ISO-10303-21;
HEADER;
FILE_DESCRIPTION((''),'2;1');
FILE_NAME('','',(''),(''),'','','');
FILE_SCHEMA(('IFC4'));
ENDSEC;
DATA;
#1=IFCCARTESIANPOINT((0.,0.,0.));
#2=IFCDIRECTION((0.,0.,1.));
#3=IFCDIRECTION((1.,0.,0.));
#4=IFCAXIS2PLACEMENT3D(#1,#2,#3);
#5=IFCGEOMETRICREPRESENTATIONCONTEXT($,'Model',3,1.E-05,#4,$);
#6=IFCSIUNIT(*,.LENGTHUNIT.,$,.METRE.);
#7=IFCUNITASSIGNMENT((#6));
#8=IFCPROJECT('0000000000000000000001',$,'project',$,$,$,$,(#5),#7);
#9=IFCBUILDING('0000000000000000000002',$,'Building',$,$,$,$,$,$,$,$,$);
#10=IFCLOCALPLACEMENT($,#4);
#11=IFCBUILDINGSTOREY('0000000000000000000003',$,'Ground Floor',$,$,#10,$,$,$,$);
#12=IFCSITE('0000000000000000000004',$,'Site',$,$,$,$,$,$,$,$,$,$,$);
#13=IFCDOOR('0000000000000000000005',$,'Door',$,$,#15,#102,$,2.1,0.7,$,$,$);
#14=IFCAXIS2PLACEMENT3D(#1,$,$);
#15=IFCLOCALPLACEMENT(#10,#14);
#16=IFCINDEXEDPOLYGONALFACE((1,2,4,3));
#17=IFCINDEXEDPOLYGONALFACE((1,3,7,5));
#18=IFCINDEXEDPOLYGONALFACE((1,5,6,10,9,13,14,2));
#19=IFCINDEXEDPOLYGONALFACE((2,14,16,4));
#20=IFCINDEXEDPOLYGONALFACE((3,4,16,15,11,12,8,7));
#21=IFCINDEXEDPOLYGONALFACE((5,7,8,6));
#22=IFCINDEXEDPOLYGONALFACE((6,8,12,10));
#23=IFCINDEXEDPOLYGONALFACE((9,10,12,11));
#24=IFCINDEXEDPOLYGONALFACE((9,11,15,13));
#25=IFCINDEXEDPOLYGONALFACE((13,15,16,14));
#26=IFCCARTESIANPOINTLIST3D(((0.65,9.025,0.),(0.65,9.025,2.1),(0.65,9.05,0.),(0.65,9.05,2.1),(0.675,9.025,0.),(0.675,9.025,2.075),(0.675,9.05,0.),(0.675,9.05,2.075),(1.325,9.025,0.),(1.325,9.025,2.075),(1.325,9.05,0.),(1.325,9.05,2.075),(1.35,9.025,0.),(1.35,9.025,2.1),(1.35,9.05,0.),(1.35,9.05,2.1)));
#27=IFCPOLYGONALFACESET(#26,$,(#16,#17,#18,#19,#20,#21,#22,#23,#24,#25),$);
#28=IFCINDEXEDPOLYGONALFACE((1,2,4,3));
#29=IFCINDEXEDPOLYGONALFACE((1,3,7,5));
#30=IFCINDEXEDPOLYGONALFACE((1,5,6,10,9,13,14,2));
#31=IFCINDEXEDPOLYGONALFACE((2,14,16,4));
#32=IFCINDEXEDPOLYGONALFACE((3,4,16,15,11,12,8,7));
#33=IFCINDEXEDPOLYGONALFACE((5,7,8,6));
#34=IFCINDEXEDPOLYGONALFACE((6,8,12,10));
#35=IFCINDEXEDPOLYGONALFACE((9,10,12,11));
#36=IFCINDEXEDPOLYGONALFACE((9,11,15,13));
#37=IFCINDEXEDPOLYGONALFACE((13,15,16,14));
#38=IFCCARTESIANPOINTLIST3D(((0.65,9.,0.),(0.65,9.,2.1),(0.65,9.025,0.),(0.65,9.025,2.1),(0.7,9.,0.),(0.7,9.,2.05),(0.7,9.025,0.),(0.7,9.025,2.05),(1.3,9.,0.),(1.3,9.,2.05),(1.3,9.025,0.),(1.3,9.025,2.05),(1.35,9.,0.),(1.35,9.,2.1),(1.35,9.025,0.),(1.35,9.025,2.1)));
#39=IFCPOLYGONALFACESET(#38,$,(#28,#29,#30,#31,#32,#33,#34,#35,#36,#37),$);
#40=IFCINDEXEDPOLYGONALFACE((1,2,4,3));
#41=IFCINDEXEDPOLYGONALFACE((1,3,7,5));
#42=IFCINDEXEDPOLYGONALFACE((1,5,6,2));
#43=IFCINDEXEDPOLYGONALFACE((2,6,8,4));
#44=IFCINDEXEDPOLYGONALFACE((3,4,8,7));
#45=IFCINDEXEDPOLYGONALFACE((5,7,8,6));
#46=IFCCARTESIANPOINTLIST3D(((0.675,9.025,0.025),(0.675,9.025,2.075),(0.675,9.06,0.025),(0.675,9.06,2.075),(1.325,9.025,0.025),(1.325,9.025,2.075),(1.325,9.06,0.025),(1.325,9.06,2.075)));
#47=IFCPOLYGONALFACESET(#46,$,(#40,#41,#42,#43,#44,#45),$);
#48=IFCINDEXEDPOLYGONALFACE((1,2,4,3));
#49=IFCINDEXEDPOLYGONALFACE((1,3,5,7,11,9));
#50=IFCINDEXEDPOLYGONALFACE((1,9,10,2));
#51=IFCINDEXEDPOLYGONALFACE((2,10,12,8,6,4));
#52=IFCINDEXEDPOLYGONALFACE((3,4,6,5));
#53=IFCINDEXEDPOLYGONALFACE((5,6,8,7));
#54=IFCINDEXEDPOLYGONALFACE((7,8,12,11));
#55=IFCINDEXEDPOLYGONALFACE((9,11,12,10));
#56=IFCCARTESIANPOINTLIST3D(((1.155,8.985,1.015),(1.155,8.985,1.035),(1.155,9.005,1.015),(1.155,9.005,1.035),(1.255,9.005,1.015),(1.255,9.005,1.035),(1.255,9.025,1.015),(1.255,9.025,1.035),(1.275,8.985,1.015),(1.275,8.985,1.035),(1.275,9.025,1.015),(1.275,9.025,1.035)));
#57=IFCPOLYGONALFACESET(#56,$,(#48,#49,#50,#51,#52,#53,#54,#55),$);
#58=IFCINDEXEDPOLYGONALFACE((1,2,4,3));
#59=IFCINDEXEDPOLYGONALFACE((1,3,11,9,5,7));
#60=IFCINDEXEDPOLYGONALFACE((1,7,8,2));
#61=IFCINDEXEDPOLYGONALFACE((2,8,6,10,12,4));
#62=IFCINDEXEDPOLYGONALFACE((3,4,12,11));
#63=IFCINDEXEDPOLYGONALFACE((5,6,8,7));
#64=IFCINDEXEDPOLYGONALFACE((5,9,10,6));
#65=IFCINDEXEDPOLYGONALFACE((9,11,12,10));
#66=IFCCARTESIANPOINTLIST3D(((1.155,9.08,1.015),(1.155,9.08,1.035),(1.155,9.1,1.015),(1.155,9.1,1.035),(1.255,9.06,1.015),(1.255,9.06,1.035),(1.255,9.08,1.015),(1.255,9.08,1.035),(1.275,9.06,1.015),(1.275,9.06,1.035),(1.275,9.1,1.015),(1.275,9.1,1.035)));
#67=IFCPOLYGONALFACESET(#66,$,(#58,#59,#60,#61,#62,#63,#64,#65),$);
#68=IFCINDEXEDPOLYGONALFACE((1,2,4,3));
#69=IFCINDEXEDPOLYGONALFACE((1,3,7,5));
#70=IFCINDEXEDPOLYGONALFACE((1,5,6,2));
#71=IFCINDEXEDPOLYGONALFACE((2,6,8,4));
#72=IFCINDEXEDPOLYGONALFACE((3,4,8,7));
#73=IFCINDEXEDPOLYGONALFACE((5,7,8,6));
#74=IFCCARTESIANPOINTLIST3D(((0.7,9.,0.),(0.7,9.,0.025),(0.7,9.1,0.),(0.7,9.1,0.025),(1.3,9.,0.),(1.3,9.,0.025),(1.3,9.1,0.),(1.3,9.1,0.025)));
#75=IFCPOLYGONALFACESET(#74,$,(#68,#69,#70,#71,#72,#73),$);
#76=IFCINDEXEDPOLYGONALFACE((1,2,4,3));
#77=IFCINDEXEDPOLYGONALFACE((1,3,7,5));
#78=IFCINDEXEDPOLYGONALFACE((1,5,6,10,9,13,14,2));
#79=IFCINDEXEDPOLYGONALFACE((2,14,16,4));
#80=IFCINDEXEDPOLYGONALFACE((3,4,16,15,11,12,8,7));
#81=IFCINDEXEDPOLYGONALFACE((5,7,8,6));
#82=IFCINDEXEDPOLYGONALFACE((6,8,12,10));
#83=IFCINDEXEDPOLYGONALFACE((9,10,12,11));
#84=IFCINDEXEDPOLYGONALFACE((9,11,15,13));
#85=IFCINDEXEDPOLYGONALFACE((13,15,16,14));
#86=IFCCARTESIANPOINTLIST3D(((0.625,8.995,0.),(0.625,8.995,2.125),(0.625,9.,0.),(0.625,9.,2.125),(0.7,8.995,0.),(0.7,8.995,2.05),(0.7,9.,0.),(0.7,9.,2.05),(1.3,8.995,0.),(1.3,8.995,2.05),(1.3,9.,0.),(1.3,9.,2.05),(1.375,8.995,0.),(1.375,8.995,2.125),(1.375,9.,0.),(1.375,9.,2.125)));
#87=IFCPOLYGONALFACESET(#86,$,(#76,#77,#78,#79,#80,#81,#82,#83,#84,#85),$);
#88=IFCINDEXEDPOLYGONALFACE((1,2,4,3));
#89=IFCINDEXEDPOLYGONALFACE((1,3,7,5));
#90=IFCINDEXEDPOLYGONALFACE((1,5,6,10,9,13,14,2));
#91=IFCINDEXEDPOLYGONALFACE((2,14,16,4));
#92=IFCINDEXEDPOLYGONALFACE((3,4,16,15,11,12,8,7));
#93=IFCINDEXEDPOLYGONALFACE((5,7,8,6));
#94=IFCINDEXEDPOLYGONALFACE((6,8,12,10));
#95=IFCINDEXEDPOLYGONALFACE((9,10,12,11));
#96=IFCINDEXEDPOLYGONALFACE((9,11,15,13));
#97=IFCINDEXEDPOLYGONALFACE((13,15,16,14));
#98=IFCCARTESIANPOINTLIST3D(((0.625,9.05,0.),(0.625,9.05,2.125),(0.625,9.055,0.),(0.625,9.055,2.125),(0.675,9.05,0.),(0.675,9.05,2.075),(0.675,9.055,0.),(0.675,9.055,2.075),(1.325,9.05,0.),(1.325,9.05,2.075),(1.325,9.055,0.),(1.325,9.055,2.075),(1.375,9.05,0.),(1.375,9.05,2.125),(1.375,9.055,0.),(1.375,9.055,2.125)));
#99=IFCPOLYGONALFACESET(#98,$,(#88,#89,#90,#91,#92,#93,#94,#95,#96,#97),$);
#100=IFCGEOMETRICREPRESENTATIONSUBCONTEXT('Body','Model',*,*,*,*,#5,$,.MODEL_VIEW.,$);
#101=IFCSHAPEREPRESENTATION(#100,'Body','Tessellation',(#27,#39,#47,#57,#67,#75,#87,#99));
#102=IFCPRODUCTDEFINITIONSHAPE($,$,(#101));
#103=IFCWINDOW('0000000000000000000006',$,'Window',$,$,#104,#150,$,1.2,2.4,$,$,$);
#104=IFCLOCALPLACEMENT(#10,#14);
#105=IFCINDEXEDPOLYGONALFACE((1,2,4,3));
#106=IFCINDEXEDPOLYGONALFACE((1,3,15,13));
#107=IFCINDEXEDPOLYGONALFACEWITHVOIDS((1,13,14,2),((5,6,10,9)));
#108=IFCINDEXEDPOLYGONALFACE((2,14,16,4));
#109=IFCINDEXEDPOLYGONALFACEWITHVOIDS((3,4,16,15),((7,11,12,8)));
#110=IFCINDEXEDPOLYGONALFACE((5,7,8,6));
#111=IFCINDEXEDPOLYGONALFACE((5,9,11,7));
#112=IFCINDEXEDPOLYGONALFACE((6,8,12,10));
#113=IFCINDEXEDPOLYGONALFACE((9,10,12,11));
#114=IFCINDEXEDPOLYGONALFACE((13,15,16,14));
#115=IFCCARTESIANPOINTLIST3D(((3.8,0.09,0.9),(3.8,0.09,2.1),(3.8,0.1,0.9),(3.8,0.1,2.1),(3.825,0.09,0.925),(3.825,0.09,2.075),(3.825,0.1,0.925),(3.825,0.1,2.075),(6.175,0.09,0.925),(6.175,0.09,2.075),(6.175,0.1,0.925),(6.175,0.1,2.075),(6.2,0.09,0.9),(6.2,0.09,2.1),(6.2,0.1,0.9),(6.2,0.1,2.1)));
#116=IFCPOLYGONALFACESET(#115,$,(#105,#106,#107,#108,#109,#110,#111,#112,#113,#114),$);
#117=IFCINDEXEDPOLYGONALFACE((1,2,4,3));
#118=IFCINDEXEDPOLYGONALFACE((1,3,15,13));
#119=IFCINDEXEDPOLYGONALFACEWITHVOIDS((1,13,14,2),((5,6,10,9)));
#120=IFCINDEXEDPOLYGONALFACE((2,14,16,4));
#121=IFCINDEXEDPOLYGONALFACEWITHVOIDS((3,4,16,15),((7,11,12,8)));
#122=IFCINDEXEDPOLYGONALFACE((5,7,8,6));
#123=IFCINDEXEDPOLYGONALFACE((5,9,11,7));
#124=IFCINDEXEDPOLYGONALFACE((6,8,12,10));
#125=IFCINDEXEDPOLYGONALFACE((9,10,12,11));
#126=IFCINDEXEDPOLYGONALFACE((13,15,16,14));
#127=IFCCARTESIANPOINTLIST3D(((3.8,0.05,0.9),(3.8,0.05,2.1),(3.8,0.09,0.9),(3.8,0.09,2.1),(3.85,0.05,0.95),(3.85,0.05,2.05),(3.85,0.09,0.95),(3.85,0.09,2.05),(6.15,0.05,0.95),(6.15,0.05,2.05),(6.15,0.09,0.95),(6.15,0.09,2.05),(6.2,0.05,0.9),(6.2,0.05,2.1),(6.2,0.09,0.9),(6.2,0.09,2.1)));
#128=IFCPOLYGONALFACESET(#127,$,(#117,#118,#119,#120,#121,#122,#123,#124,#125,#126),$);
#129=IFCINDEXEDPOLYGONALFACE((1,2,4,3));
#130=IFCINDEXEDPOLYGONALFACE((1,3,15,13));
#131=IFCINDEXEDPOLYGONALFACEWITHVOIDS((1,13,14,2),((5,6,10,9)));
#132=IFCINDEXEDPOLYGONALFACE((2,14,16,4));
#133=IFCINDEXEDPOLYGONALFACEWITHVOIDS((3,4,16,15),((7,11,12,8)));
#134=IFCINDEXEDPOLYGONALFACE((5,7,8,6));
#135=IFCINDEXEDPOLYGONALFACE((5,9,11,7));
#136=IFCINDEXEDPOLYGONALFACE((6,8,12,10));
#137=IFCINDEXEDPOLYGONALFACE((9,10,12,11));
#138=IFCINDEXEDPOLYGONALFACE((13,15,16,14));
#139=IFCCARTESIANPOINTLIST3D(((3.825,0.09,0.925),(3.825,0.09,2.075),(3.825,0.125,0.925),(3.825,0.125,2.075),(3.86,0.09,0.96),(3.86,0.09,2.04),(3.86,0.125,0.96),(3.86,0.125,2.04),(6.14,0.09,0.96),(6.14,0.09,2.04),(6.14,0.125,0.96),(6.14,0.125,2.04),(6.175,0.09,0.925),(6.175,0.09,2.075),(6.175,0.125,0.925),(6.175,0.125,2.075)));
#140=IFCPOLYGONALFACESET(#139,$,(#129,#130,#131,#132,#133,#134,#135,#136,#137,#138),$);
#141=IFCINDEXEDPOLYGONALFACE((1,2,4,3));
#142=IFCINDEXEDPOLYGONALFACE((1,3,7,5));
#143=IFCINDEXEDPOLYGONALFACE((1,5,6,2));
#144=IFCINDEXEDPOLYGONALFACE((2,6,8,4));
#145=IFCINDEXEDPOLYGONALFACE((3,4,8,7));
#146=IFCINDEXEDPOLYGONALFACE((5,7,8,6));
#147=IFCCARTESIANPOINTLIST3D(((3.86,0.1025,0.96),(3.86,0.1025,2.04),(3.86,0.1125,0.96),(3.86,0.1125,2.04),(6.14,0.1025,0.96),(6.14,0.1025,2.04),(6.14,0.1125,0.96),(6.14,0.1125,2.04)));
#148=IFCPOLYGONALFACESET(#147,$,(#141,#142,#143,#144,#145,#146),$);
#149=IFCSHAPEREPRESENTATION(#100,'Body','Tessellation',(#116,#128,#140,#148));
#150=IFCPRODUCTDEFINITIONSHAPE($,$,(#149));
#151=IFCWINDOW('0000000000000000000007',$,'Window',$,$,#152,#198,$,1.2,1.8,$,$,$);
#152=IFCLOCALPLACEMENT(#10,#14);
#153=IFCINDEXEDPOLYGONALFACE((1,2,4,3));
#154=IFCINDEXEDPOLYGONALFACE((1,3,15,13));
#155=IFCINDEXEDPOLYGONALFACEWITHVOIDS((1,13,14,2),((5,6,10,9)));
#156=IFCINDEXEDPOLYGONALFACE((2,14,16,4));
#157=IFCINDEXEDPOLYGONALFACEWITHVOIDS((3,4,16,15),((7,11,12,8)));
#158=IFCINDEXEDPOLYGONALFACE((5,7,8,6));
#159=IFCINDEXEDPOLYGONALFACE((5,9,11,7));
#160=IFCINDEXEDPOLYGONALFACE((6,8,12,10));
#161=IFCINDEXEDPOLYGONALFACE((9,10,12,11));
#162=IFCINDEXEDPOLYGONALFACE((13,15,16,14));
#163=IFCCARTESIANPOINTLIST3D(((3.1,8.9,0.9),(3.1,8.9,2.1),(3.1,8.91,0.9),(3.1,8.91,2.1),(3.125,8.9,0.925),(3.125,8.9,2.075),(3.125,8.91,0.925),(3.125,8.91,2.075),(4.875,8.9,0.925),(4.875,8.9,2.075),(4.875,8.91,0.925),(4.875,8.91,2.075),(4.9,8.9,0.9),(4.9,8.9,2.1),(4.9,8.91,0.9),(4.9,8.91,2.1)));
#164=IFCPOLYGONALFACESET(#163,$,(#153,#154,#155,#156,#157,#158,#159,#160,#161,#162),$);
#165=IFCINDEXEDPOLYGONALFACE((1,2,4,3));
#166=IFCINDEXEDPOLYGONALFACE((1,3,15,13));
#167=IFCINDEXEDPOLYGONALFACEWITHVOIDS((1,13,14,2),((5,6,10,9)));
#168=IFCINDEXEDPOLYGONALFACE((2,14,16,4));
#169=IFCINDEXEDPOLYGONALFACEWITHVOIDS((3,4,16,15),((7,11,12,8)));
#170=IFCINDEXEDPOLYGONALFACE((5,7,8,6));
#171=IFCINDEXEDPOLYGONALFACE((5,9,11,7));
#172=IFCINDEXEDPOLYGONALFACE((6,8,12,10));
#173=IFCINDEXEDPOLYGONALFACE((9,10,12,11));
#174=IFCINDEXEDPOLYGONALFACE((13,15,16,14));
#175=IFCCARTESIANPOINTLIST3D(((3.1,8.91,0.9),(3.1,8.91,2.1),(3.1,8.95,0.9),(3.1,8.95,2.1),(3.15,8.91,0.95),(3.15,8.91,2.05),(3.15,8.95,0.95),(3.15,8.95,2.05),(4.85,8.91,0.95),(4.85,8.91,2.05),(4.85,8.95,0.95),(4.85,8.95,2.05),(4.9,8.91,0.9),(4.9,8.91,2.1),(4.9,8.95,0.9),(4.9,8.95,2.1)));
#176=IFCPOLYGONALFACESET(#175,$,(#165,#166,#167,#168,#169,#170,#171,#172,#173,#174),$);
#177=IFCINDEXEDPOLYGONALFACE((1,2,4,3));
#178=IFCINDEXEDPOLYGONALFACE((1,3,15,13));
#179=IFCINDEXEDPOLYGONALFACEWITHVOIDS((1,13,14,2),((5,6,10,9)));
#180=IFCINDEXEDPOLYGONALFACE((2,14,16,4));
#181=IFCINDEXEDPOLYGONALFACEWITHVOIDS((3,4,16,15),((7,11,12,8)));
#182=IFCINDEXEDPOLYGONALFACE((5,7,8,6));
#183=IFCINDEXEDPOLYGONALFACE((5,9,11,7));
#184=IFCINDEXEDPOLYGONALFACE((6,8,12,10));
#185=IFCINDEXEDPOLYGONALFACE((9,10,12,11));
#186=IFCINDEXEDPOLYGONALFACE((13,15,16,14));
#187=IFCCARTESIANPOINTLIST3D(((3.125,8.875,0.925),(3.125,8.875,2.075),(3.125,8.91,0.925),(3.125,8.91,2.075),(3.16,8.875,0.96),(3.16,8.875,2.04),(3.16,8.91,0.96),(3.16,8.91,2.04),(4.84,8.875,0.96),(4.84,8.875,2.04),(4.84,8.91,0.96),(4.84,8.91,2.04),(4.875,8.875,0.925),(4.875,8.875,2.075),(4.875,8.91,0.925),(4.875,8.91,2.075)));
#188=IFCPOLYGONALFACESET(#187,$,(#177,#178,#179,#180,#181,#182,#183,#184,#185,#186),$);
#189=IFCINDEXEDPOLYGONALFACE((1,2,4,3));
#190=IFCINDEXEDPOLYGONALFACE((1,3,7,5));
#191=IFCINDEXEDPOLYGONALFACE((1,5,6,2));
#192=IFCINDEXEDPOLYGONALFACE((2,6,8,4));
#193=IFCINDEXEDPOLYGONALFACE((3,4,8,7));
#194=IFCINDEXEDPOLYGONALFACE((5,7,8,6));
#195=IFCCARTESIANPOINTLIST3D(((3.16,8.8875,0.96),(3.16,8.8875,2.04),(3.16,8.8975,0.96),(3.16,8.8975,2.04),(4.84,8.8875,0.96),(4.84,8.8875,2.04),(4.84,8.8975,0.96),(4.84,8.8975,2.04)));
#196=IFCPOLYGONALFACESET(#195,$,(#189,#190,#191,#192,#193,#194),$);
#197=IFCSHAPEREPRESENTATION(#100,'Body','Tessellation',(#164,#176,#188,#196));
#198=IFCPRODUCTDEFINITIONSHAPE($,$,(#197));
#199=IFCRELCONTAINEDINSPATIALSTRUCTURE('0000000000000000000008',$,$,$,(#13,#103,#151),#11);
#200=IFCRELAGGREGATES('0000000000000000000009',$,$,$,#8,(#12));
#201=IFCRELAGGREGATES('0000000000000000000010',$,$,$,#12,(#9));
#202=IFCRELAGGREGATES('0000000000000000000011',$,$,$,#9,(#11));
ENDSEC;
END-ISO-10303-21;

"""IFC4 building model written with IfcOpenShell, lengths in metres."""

from ifc_helpers import new_model, si_unit, frame, origin_with_axes, place, context, subcontext, project, spatial, line, indexed_curve, outline, extrude, element, save


model = new_model("IFC4")

# Units and contexts
model_context = context("Model", 3, precision=1e-05, world=origin_with_axes())
body_context = subcontext(model_context, "Body", "Model", "MODEL_VIEW")
ifc_project = project(units=[si_unit("LENGTHUNIT", "METRE")], contexts=[model_context])

# Site, building, storey
site = spatial("IfcSite", under=ifc_project, Name="Site")
building = spatial("IfcBuilding", under=site, Name="Building")
storey_placement = place(None, origin_with_axes())
storey = spatial("IfcBuildingStorey", under=building, at=storey_placement, Name="Ground Floor")

# Door
door_1_placement = place(storey_placement, frame((0.65, 9.0, 0.0), z_axis=(0.0, 0.0, 1.0), x_axis=(1.0, 0.0, 0.0)))
element("IfcDoor", 1, at=door_1_placement, inside=storey, Name="Door", OverallHeight=2.1, OverallWidth=0.7, context=body_context, shape_type="SweptSolid", body=[
    extrude(outline(indexed_curve([(0.0, 0.0), (0.0, 2.1), (0.7, 2.1), (0.7, 0.0), (0.675, 0.0), (0.675, 2.075), (0.025, 2.075), (0.025, 0.0)], segments=[line(1, 2, 3, 4, 5, 6, 7, 8, 1)])), frame((0.0, 0.025, 0.0), z_axis=(0.0, -1.0, 0.0), x_axis=(1.0, 0.0, 0.0)), (0.0, 0.0, -1.0), 0.025),
    extrude(outline(indexed_curve([(0.0, 0.0), (0.0, 2.1), (0.7, 2.1), (0.7, 0.0), (0.65, 0.0), (0.65, 2.05), (0.05, 2.05), (0.05, 0.0)], segments=[line(1, 2, 3, 4, 5, 6, 7, 8, 1)])), frame((0.0, 0.0, 0.0), z_axis=(0.0, -1.0, 0.0), x_axis=(1.0, 0.0, 0.0)), (0.0, 0.0, -1.0), 0.025),
    extrude(outline(indexed_curve([(0.0, 0.0), (0.65, 0.0), (0.65, 0.035), (0.0, 0.035)], segments=[line(1, 2, 3, 4, 1)])), frame((0.025, 0.025, 0.025), z_axis=(0.0, 0.0, 1.0), x_axis=(1.0, 0.0, 0.0)), (0.0, 0.0, 1.0), 2.05),
    extrude(outline(indexed_curve([(0.0, 0.0), (0.0, -0.04), (-0.12, -0.04), (-0.12, -0.02), (-0.02, -0.02), (-0.02, 0.0)], segments=[line(1, 2, 3, 4, 5, 6, 1)])), frame((0.625, 0.025, 1.015), z_axis=(0.0, 0.0, 1.0), x_axis=(1.0, 0.0, 0.0)), (0.0, 0.0, 1.0), 0.02),
    extrude(outline(indexed_curve([(0.0, 0.0), (0.0, 0.04), (-0.12, 0.04), (-0.12, 0.02), (-0.02, 0.02), (-0.02, 0.0)], segments=[line(1, 2, 3, 4, 5, 6, 1)])), frame((0.625, 0.06, 1.015), z_axis=(0.0, 0.0, 1.0), x_axis=(1.0, 0.0, 0.0)), (0.0, 0.0, 1.0), 0.02),
    extrude(outline(indexed_curve([(0.0, 0.0), (0.6, 0.0), (0.6, 0.1), (0.0, 0.1)], segments=[line(1, 2, 3, 4, 1)])), frame((0.05, 0.0, 0.0), z_axis=(0.0, 0.0, 1.0), x_axis=(1.0, 0.0, 0.0)), (0.0, 0.0, 1.0), 0.025),
    extrude(outline(indexed_curve([(0.0, 0.0), (0.0, 2.125), (0.75, 2.125), (0.75, 0.0), (0.675, 0.0), (0.675, 2.05), (0.075, 2.05), (0.075, 0.0)], segments=[line(1, 2, 3, 4, 5, 6, 7, 8, 1)])), frame((-0.025, -0.005, 0.0), z_axis=(0.0, -1.0, 0.0), x_axis=(1.0, 0.0, 0.0)), (0.0, 0.0, -1.0), 0.005),
    extrude(outline(indexed_curve([(0.0, 0.0), (0.0, 2.125), (0.75, 2.125), (0.75, 0.0), (0.7, 0.0), (0.7, 2.075), (0.05, 2.075), (0.05, 0.0)], segments=[line(1, 2, 3, 4, 5, 6, 7, 8, 1)])), frame((-0.025, 0.05, 0.0), z_axis=(0.0, -1.0, 0.0), x_axis=(1.0, 0.0, 0.0)), (0.0, 0.0, -1.0), 0.005),
])

# Windows
window_1_placement = place(storey_placement, frame((3.8, 0.0, 0.9), z_axis=(0.0, 0.0, 1.0), x_axis=(1.0, 0.0, 0.0)))
element("IfcWindow", 2, at=window_1_placement, inside=storey, Name="Window", OverallHeight=1.2, OverallWidth=2.4, context=body_context, shape_type="SweptSolid", body=[
    extrude(outline(indexed_curve([(0.0, 0.0), (2.4, 0.0), (2.4, 1.2), (0.0, 1.2)], segments=[line(1, 2, 3, 4, 1)]), holes=[indexed_curve([(0.025, 0.025), (2.375, 0.025), (2.375, 1.175), (0.025, 1.175)], segments=[line(1, 2, 3, 4, 1)])]), frame((0.0, 0.09, 0.0), z_axis=(0.0, -1.0, 0.0), x_axis=(1.0, 0.0, 0.0)), (0.0, 0.0, -1.0), 0.01),
    extrude(outline(indexed_curve([(0.0, 0.0), (2.4, 0.0), (2.4, 1.2), (0.0, 1.2)], segments=[line(1, 2, 3, 4, 1)]), holes=[indexed_curve([(0.05, 0.05), (2.35, 0.05), (2.35, 1.15), (0.05, 1.15)], segments=[line(1, 2, 3, 4, 1)])]), frame((0.0, 0.05, 0.0), z_axis=(0.0, -1.0, 0.0), x_axis=(1.0, 0.0, 0.0)), (0.0, 0.0, -1.0), 0.04),
    extrude(outline(indexed_curve([(0.0, 0.0), (2.35, 0.0), (2.35, 1.15), (0.0, 1.15)], segments=[line(1, 2, 3, 4, 1)]), holes=[indexed_curve([(0.035, 0.035), (2.315, 0.035), (2.315, 1.115), (0.035, 1.115)], segments=[line(1, 2, 3, 4, 1)])]), frame((0.025, 0.09, 0.025), z_axis=(0.0, -1.0, 0.0), x_axis=(1.0, 0.0, 0.0)), (0.0, 0.0, -1.0), 0.035),
    extrude(outline(indexed_curve([(0.035, 0.035), (2.315, 0.035), (2.315, 1.115), (0.035, 1.115)], segments=[line(1, 2, 3, 4, 1)])), frame((0.025, 0.1025, 0.025), z_axis=(0.0, -1.0, 0.0), x_axis=(1.0, 0.0, 0.0)), (0.0, 0.0, -1.0), 0.01),
])
window_2_placement = place(storey_placement, frame((4.9, 9.0, 0.9), z_axis=(0.0, 0.0, 1.0), x_axis=(-1.0, 0.0, 0.0)))
element("IfcWindow", 3, at=window_2_placement, inside=storey, Name="Window", OverallHeight=1.2, OverallWidth=1.8, context=body_context, shape_type="SweptSolid", body=[
    extrude(outline(indexed_curve([(0.0, 0.0), (1.8, 0.0), (1.8, 1.2), (0.0, 1.2)], segments=[line(1, 2, 3, 4, 1)]), holes=[indexed_curve([(0.025, 0.025), (1.775, 0.025), (1.775, 1.175), (0.025, 1.175)], segments=[line(1, 2, 3, 4, 1)])]), frame((0.0, 0.09, 0.0), z_axis=(0.0, -1.0, 0.0), x_axis=(1.0, 0.0, 0.0)), (0.0, 0.0, -1.0), 0.01),
    extrude(outline(indexed_curve([(0.0, 0.0), (1.8, 0.0), (1.8, 1.2), (0.0, 1.2)], segments=[line(1, 2, 3, 4, 1)]), holes=[indexed_curve([(0.05, 0.05), (1.75, 0.05), (1.75, 1.15), (0.05, 1.15)], segments=[line(1, 2, 3, 4, 1)])]), frame((0.0, 0.05, 0.0), z_axis=(0.0, -1.0, 0.0), x_axis=(1.0, 0.0, 0.0)), (0.0, 0.0, -1.0), 0.04),
    extrude(outline(indexed_curve([(0.0, 0.0), (1.75, 0.0), (1.75, 1.15), (0.0, 1.15)], segments=[line(1, 2, 3, 4, 1)]), holes=[indexed_curve([(0.035, 0.035), (1.715, 0.035), (1.715, 1.115), (0.035, 1.115)], segments=[line(1, 2, 3, 4, 1)])]), frame((0.025, 0.09, 0.025), z_axis=(0.0, -1.0, 0.0), x_axis=(1.0, 0.0, 0.0)), (0.0, 0.0, -1.0), 0.035),
    extrude(outline(indexed_curve([(0.035, 0.035), (1.715, 0.035), (1.715, 1.115), (0.035, 1.115)], segments=[line(1, 2, 3, 4, 1)])), frame((0.025, 0.1025, 0.025), z_axis=(0.0, -1.0, 0.0), x_axis=(1.0, 0.0, 0.0)), (0.0, 0.0, -1.0), 0.01),
])

save(model, "model.ifc")
